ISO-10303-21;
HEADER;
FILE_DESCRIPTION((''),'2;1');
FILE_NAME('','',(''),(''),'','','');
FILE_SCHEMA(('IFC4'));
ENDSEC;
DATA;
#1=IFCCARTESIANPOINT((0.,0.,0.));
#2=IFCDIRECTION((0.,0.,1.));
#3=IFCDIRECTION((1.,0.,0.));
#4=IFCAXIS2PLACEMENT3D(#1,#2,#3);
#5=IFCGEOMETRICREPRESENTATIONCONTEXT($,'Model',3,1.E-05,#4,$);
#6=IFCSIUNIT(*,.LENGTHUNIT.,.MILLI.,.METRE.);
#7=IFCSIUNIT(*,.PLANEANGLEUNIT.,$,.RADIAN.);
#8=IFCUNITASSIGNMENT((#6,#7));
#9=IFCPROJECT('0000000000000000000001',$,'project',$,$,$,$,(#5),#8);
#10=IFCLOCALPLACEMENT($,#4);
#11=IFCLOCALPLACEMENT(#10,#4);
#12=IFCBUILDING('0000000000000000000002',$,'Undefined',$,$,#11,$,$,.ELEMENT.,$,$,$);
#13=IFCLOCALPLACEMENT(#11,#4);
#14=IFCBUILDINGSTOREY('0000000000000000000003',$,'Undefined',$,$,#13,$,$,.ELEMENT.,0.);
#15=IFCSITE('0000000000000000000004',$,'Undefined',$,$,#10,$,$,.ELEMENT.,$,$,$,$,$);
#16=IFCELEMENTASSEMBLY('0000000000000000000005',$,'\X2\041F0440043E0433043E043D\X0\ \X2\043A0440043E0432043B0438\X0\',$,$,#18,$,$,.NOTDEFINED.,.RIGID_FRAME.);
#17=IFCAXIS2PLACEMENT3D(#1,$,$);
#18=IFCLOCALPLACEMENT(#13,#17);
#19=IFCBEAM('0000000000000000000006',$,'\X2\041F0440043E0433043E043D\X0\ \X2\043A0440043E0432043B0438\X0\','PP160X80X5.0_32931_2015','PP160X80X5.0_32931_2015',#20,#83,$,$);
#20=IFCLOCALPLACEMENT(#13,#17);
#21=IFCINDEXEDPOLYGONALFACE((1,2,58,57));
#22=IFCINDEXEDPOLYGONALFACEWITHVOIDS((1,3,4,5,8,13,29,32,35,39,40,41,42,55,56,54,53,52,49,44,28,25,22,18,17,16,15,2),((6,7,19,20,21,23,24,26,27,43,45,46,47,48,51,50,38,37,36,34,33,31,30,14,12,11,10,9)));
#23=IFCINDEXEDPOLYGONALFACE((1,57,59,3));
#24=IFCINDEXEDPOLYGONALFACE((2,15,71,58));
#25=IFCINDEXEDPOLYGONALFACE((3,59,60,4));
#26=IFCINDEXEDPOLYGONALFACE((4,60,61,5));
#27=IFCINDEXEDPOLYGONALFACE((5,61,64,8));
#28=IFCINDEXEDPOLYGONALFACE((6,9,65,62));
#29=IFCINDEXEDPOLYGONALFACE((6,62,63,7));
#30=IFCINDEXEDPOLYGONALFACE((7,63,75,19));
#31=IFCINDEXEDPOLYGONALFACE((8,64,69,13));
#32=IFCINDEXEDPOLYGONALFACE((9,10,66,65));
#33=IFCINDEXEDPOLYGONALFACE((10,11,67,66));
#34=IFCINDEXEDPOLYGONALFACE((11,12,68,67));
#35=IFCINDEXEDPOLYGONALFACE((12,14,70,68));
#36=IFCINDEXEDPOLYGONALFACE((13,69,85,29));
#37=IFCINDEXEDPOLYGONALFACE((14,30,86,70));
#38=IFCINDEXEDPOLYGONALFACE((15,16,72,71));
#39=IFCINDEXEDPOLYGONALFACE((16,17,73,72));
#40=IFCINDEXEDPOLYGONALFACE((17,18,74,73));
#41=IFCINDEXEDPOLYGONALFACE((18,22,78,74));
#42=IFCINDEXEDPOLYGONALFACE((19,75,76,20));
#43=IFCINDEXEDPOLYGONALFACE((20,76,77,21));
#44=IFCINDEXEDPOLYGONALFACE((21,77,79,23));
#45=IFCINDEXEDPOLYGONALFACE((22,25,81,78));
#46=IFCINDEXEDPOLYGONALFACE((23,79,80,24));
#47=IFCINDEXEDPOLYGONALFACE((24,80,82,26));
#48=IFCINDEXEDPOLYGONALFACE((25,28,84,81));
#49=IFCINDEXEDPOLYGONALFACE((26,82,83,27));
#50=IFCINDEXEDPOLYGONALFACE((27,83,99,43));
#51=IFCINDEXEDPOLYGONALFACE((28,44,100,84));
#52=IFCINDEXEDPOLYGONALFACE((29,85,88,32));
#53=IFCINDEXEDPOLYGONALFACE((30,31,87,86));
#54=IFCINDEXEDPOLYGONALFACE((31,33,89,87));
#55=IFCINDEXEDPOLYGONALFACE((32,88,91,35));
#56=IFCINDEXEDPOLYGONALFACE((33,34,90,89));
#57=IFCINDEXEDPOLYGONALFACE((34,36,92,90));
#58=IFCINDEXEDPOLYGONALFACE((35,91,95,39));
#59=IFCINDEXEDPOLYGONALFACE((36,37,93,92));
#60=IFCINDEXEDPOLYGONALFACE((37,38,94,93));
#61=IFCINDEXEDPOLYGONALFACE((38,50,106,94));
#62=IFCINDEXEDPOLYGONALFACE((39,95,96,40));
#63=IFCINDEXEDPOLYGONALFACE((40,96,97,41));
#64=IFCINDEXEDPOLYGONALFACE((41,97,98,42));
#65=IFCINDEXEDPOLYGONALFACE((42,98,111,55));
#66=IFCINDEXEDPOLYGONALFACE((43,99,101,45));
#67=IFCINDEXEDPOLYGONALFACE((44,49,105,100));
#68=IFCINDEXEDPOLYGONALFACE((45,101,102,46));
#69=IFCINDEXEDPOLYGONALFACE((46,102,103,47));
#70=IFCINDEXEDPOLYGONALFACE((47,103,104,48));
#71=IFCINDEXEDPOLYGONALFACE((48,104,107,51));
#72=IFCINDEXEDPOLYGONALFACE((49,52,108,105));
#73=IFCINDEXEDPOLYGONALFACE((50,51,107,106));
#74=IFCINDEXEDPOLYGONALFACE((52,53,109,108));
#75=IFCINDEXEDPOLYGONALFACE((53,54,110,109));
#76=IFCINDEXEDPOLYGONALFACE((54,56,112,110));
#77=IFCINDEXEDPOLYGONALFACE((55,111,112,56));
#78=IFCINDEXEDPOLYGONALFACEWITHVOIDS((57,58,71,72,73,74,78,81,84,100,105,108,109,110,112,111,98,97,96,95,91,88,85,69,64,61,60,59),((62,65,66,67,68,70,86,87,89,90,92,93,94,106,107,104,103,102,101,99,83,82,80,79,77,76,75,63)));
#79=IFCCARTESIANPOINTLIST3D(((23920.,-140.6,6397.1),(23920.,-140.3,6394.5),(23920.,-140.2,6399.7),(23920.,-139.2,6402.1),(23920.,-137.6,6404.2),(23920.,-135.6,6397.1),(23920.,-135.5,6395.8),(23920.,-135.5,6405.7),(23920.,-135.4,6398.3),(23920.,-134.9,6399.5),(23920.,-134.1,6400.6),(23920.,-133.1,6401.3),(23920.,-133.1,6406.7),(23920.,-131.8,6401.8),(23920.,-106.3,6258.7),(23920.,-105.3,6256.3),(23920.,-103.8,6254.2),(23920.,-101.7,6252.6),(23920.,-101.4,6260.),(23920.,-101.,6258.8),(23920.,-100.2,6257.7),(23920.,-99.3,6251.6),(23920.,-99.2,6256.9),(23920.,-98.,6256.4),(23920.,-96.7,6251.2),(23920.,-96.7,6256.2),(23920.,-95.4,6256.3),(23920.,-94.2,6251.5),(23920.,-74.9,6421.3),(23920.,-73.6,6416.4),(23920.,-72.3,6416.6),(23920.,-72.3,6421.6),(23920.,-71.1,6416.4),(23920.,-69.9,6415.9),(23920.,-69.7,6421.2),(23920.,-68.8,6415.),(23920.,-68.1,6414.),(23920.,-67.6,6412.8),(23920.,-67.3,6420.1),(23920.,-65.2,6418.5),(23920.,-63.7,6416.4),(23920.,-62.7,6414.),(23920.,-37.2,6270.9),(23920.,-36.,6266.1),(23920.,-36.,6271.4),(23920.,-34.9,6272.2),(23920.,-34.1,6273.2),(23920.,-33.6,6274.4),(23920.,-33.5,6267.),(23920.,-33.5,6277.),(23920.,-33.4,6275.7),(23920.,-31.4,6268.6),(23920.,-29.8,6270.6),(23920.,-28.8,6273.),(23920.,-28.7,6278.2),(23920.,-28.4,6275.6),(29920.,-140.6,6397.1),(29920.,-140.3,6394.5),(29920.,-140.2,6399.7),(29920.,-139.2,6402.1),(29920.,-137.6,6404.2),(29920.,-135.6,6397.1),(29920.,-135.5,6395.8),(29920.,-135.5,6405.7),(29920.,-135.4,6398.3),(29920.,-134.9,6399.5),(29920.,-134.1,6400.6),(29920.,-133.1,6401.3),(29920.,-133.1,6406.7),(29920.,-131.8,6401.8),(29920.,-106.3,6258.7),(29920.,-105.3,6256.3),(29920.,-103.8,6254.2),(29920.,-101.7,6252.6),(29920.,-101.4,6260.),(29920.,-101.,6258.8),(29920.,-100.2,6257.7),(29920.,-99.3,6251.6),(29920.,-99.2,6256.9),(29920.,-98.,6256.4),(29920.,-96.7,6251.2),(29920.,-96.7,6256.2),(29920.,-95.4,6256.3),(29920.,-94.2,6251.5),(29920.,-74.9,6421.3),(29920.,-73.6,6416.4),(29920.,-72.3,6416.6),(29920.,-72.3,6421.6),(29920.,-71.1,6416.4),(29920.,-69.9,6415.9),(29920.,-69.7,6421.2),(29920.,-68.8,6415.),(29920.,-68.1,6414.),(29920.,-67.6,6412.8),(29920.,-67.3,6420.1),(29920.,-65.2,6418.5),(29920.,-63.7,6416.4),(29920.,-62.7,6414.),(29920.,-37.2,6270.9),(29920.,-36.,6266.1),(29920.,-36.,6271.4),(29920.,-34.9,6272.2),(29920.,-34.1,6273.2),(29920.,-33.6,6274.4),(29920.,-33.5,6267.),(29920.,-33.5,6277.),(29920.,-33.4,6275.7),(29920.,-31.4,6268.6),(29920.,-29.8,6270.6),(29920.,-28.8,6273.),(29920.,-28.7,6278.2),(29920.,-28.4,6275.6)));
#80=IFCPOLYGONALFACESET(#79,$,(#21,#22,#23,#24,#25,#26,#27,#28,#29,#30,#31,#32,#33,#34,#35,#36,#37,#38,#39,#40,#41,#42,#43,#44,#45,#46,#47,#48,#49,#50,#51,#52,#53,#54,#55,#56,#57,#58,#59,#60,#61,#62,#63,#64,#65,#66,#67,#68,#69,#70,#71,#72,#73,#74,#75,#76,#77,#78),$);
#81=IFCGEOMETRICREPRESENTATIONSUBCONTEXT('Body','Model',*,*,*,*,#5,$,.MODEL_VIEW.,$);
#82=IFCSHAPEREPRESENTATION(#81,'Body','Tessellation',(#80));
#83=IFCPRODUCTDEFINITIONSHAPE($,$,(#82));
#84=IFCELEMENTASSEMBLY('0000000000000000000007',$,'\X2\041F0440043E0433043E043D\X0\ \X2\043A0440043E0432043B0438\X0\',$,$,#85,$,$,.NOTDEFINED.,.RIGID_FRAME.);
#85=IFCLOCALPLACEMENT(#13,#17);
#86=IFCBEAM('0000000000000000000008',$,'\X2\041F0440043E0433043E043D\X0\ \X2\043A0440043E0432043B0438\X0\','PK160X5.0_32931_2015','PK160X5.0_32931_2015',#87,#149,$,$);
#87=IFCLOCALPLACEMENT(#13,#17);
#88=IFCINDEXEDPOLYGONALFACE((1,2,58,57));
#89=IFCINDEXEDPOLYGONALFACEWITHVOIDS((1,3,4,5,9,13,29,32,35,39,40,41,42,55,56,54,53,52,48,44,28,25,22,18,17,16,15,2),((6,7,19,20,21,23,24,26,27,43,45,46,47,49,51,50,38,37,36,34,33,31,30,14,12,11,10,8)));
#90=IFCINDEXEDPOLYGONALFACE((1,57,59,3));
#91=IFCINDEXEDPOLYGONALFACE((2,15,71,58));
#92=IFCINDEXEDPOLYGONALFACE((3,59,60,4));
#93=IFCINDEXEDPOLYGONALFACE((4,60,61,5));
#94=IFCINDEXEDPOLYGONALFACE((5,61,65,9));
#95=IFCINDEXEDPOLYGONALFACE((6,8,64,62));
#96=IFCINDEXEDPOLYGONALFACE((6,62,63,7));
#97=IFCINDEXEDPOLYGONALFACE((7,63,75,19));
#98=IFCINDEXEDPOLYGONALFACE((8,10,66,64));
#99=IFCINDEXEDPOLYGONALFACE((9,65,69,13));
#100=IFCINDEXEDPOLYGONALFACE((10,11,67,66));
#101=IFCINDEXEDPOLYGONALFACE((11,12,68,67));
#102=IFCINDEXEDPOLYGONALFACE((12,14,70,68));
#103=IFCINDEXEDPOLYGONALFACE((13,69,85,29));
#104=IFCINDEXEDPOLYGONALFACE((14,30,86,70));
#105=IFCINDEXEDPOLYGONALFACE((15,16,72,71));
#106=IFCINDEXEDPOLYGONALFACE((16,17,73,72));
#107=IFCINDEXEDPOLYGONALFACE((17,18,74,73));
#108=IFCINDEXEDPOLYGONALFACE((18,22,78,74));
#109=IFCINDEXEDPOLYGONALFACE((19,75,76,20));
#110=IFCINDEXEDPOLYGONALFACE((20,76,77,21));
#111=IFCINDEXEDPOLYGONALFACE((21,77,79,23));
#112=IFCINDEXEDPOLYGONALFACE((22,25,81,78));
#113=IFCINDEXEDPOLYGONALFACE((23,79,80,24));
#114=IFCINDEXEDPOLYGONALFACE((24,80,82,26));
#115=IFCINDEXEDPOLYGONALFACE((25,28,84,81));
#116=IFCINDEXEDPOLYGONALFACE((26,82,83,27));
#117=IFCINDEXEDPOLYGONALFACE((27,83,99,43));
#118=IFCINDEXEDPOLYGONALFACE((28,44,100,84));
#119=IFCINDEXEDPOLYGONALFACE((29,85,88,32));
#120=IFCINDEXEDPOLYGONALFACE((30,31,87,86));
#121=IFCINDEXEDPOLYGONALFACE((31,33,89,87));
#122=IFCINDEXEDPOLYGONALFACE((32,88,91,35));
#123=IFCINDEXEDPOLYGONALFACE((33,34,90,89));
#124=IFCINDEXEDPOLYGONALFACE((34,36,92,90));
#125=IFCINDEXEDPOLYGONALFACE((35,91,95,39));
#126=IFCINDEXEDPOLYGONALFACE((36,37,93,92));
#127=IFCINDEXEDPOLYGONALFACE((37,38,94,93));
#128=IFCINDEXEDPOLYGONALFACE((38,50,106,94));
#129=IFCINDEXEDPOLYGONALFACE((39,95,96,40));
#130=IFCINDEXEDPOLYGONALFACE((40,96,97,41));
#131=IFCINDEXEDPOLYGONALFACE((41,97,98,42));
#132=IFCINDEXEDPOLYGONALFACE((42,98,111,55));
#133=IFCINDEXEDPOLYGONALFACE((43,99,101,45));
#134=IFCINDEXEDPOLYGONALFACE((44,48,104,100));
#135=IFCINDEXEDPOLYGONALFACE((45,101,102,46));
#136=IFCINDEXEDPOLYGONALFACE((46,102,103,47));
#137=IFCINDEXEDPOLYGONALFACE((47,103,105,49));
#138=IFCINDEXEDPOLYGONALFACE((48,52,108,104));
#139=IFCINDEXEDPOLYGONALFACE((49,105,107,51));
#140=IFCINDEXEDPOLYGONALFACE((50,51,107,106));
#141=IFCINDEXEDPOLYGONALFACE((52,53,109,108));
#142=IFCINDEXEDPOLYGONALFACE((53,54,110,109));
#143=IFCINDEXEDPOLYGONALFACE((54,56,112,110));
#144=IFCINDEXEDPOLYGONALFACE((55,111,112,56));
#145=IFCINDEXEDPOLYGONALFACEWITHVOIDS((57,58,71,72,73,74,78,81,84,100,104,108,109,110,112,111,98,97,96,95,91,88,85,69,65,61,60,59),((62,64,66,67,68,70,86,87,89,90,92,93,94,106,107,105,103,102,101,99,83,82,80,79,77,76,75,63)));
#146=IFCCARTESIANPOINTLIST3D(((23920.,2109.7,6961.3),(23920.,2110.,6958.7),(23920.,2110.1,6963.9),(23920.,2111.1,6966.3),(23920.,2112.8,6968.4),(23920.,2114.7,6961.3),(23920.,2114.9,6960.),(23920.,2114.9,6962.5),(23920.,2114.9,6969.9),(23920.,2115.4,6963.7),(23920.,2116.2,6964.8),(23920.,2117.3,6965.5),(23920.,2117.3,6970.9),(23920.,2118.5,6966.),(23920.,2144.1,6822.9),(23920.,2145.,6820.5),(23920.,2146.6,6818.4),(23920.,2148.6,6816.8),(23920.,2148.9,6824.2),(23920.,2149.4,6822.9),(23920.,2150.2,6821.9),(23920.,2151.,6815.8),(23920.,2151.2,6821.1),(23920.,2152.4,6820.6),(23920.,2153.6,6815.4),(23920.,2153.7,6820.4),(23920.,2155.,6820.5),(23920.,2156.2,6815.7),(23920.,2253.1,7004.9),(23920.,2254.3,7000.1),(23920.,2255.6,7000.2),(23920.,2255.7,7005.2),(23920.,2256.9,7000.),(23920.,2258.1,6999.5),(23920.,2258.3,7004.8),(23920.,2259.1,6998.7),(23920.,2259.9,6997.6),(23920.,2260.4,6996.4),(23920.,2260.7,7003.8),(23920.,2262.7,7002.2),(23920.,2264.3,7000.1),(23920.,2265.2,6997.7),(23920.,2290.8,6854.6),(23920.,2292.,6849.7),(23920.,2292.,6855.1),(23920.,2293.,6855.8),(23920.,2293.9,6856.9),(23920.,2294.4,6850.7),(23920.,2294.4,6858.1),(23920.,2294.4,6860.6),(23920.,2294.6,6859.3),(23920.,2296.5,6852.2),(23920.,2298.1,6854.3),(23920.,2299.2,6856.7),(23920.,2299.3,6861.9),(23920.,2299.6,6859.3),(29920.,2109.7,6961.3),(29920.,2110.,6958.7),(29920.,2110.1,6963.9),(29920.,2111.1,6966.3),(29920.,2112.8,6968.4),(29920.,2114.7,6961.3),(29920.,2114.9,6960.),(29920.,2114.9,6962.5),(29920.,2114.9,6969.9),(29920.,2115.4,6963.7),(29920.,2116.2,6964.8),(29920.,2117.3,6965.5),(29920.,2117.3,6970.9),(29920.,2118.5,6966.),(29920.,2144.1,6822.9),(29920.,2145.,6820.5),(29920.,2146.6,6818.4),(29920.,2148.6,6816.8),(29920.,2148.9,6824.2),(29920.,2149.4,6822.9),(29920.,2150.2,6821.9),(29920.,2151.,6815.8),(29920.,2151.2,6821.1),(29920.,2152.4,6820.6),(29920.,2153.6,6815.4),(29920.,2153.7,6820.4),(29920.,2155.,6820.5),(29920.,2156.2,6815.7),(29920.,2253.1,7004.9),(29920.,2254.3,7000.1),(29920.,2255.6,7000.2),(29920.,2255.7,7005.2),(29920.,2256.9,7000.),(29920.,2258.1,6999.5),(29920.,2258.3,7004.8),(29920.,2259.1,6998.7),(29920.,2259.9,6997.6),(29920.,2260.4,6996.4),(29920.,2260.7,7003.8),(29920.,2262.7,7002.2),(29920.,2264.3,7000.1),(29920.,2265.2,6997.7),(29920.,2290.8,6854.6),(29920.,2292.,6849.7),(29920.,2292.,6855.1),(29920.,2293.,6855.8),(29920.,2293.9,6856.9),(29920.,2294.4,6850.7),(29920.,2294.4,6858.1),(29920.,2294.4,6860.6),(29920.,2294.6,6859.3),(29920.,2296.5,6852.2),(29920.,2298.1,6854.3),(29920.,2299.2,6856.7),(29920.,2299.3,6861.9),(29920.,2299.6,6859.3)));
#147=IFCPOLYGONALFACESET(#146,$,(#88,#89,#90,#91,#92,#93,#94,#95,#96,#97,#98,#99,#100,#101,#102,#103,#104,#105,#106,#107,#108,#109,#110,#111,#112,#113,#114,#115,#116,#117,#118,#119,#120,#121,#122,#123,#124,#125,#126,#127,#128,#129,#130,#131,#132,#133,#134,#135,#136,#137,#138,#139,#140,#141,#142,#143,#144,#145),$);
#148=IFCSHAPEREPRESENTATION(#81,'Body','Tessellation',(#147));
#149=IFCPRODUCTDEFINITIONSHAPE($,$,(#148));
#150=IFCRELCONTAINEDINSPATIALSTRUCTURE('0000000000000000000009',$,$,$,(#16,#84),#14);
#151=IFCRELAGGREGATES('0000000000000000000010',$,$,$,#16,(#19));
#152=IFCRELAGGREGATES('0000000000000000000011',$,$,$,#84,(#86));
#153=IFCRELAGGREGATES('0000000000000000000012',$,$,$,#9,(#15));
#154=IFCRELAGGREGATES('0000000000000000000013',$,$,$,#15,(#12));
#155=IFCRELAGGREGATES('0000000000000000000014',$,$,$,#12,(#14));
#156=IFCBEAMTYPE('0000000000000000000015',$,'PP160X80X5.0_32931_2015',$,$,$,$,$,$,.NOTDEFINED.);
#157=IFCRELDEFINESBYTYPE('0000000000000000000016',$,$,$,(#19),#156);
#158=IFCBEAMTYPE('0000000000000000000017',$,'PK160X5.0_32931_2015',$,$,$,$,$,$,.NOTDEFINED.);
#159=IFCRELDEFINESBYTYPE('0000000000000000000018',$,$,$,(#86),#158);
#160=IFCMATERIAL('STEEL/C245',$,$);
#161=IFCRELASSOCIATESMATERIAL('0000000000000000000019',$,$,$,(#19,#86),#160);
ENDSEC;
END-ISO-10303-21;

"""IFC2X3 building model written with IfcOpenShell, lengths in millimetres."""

from ifc_helpers import new_model, si_unit, frame, origin_with_axes, origin_2d_with_axis, place, context, subcontext, project, spatial, hollow_rectangle, extrude, material, type_object, element, aggregate, save


model = new_model("IFC2X3")

# Units and contexts
model_context = context("Model", 3, precision=1e-05, world=origin_with_axes())
body_context = subcontext(model_context, "Body", "Model", "MODEL_VIEW")
ifc_project = project(units=[si_unit("LENGTHUNIT", "METRE", prefix="MILLI"), si_unit("PLANEANGLEUNIT", "RADIAN")], contexts=[model_context])

# Site, building, storey
site_placement = place(None, origin_with_axes())
site = spatial("IfcSite", under=ifc_project, at=site_placement, Name="Undefined", CompositionType="ELEMENT")
building_placement = place(site_placement, origin_with_axes())
building = spatial("IfcBuilding", under=site, at=building_placement, Name="Undefined", CompositionType="ELEMENT")
storey_placement = place(building_placement, origin_with_axes())
storey = spatial("IfcBuildingStorey", under=building, at=storey_placement, Name="Undefined", CompositionType="ELEMENT", Elevation=0.0)

# Shared definitions
ifc_material = material(Name="STEEL/C245")

# Element assemblies, beams
assembly_1_placement = place(storey_placement, origin_with_axes())
assembly_1 = element("IfcElementAssembly", 1, at=assembly_1_placement, inside=storey, Name="Прогон кровли", AssemblyPlace="NOTDEFINED", PredefinedType="RIGID_FRAME")
beam_type_1 = type_object("IfcBeamType", Name="PP160X80X5.0_32931_2015", PredefinedType="NOTDEFINED")
beam_1_placement = place(assembly_1_placement, frame((23920.0, -84.5, 6336.4), z_axis=(0.0, -0.243188, 0.969979), x_axis=(1.0, 0.0, 0.0)))
beam_1 = element("IfcBeam", 2, at=beam_1_placement, type_object=beam_type_1, material=ifc_material, Name="Прогон кровли", Description="PP160X80X5.0_32931_2015", ObjectType="PP160X80X5.0_32931_2015", context=body_context, shape_type="SweptSolid", body=[
    extrude(hollow_rectangle(XDim=80.0, YDim=160.0, WallThickness=5.0, InnerFilletRadius=5.0, OuterFilletRadius=10.0, at=origin_2d_with_axis()), frame((6000.0, 0.0, 0.0), z_axis=(-1.0, 0.0, 0.0), x_axis=(0.0, -1.0, 0.0)), (0.0, 0.0, 1.0), 6000.0),
])
aggregate(assembly_1, [beam_1])
assembly_2_placement = place(storey_placement, origin_with_axes())
assembly_2 = element("IfcElementAssembly", 3, at=assembly_2_placement, inside=storey, Name="Прогон кровли", AssemblyPlace="NOTDEFINED", PredefinedType="RIGID_FRAME")
beam_type_2 = type_object("IfcBeamType", Name="PK160X5.0_32931_2015", PredefinedType="NOTDEFINED")
beam_2_placement = place(assembly_2_placement, frame((23920.0, 2204.6, 6910.3), z_axis=(0.0, -0.243188, 0.969979), x_axis=(1.0, 0.0, 0.0)))
beam_2 = element("IfcBeam", 4, at=beam_2_placement, type_object=beam_type_2, material=ifc_material, Name="Прогон кровли", Description="PK160X5.0_32931_2015", ObjectType="PK160X5.0_32931_2015", context=body_context, shape_type="SweptSolid", body=[
    extrude(hollow_rectangle(XDim=160.0, YDim=160.0, WallThickness=5.0, InnerFilletRadius=5.0, OuterFilletRadius=10.0, at=origin_2d_with_axis()), frame((6000.0, 0.0, 0.0), z_axis=(-1.0, 0.0, 0.0), x_axis=(0.0, -1.0, 0.0)), (0.0, 0.0, 1.0), 6000.0),
])
aggregate(assembly_2, [beam_2])

save(model, "model.ifc")
